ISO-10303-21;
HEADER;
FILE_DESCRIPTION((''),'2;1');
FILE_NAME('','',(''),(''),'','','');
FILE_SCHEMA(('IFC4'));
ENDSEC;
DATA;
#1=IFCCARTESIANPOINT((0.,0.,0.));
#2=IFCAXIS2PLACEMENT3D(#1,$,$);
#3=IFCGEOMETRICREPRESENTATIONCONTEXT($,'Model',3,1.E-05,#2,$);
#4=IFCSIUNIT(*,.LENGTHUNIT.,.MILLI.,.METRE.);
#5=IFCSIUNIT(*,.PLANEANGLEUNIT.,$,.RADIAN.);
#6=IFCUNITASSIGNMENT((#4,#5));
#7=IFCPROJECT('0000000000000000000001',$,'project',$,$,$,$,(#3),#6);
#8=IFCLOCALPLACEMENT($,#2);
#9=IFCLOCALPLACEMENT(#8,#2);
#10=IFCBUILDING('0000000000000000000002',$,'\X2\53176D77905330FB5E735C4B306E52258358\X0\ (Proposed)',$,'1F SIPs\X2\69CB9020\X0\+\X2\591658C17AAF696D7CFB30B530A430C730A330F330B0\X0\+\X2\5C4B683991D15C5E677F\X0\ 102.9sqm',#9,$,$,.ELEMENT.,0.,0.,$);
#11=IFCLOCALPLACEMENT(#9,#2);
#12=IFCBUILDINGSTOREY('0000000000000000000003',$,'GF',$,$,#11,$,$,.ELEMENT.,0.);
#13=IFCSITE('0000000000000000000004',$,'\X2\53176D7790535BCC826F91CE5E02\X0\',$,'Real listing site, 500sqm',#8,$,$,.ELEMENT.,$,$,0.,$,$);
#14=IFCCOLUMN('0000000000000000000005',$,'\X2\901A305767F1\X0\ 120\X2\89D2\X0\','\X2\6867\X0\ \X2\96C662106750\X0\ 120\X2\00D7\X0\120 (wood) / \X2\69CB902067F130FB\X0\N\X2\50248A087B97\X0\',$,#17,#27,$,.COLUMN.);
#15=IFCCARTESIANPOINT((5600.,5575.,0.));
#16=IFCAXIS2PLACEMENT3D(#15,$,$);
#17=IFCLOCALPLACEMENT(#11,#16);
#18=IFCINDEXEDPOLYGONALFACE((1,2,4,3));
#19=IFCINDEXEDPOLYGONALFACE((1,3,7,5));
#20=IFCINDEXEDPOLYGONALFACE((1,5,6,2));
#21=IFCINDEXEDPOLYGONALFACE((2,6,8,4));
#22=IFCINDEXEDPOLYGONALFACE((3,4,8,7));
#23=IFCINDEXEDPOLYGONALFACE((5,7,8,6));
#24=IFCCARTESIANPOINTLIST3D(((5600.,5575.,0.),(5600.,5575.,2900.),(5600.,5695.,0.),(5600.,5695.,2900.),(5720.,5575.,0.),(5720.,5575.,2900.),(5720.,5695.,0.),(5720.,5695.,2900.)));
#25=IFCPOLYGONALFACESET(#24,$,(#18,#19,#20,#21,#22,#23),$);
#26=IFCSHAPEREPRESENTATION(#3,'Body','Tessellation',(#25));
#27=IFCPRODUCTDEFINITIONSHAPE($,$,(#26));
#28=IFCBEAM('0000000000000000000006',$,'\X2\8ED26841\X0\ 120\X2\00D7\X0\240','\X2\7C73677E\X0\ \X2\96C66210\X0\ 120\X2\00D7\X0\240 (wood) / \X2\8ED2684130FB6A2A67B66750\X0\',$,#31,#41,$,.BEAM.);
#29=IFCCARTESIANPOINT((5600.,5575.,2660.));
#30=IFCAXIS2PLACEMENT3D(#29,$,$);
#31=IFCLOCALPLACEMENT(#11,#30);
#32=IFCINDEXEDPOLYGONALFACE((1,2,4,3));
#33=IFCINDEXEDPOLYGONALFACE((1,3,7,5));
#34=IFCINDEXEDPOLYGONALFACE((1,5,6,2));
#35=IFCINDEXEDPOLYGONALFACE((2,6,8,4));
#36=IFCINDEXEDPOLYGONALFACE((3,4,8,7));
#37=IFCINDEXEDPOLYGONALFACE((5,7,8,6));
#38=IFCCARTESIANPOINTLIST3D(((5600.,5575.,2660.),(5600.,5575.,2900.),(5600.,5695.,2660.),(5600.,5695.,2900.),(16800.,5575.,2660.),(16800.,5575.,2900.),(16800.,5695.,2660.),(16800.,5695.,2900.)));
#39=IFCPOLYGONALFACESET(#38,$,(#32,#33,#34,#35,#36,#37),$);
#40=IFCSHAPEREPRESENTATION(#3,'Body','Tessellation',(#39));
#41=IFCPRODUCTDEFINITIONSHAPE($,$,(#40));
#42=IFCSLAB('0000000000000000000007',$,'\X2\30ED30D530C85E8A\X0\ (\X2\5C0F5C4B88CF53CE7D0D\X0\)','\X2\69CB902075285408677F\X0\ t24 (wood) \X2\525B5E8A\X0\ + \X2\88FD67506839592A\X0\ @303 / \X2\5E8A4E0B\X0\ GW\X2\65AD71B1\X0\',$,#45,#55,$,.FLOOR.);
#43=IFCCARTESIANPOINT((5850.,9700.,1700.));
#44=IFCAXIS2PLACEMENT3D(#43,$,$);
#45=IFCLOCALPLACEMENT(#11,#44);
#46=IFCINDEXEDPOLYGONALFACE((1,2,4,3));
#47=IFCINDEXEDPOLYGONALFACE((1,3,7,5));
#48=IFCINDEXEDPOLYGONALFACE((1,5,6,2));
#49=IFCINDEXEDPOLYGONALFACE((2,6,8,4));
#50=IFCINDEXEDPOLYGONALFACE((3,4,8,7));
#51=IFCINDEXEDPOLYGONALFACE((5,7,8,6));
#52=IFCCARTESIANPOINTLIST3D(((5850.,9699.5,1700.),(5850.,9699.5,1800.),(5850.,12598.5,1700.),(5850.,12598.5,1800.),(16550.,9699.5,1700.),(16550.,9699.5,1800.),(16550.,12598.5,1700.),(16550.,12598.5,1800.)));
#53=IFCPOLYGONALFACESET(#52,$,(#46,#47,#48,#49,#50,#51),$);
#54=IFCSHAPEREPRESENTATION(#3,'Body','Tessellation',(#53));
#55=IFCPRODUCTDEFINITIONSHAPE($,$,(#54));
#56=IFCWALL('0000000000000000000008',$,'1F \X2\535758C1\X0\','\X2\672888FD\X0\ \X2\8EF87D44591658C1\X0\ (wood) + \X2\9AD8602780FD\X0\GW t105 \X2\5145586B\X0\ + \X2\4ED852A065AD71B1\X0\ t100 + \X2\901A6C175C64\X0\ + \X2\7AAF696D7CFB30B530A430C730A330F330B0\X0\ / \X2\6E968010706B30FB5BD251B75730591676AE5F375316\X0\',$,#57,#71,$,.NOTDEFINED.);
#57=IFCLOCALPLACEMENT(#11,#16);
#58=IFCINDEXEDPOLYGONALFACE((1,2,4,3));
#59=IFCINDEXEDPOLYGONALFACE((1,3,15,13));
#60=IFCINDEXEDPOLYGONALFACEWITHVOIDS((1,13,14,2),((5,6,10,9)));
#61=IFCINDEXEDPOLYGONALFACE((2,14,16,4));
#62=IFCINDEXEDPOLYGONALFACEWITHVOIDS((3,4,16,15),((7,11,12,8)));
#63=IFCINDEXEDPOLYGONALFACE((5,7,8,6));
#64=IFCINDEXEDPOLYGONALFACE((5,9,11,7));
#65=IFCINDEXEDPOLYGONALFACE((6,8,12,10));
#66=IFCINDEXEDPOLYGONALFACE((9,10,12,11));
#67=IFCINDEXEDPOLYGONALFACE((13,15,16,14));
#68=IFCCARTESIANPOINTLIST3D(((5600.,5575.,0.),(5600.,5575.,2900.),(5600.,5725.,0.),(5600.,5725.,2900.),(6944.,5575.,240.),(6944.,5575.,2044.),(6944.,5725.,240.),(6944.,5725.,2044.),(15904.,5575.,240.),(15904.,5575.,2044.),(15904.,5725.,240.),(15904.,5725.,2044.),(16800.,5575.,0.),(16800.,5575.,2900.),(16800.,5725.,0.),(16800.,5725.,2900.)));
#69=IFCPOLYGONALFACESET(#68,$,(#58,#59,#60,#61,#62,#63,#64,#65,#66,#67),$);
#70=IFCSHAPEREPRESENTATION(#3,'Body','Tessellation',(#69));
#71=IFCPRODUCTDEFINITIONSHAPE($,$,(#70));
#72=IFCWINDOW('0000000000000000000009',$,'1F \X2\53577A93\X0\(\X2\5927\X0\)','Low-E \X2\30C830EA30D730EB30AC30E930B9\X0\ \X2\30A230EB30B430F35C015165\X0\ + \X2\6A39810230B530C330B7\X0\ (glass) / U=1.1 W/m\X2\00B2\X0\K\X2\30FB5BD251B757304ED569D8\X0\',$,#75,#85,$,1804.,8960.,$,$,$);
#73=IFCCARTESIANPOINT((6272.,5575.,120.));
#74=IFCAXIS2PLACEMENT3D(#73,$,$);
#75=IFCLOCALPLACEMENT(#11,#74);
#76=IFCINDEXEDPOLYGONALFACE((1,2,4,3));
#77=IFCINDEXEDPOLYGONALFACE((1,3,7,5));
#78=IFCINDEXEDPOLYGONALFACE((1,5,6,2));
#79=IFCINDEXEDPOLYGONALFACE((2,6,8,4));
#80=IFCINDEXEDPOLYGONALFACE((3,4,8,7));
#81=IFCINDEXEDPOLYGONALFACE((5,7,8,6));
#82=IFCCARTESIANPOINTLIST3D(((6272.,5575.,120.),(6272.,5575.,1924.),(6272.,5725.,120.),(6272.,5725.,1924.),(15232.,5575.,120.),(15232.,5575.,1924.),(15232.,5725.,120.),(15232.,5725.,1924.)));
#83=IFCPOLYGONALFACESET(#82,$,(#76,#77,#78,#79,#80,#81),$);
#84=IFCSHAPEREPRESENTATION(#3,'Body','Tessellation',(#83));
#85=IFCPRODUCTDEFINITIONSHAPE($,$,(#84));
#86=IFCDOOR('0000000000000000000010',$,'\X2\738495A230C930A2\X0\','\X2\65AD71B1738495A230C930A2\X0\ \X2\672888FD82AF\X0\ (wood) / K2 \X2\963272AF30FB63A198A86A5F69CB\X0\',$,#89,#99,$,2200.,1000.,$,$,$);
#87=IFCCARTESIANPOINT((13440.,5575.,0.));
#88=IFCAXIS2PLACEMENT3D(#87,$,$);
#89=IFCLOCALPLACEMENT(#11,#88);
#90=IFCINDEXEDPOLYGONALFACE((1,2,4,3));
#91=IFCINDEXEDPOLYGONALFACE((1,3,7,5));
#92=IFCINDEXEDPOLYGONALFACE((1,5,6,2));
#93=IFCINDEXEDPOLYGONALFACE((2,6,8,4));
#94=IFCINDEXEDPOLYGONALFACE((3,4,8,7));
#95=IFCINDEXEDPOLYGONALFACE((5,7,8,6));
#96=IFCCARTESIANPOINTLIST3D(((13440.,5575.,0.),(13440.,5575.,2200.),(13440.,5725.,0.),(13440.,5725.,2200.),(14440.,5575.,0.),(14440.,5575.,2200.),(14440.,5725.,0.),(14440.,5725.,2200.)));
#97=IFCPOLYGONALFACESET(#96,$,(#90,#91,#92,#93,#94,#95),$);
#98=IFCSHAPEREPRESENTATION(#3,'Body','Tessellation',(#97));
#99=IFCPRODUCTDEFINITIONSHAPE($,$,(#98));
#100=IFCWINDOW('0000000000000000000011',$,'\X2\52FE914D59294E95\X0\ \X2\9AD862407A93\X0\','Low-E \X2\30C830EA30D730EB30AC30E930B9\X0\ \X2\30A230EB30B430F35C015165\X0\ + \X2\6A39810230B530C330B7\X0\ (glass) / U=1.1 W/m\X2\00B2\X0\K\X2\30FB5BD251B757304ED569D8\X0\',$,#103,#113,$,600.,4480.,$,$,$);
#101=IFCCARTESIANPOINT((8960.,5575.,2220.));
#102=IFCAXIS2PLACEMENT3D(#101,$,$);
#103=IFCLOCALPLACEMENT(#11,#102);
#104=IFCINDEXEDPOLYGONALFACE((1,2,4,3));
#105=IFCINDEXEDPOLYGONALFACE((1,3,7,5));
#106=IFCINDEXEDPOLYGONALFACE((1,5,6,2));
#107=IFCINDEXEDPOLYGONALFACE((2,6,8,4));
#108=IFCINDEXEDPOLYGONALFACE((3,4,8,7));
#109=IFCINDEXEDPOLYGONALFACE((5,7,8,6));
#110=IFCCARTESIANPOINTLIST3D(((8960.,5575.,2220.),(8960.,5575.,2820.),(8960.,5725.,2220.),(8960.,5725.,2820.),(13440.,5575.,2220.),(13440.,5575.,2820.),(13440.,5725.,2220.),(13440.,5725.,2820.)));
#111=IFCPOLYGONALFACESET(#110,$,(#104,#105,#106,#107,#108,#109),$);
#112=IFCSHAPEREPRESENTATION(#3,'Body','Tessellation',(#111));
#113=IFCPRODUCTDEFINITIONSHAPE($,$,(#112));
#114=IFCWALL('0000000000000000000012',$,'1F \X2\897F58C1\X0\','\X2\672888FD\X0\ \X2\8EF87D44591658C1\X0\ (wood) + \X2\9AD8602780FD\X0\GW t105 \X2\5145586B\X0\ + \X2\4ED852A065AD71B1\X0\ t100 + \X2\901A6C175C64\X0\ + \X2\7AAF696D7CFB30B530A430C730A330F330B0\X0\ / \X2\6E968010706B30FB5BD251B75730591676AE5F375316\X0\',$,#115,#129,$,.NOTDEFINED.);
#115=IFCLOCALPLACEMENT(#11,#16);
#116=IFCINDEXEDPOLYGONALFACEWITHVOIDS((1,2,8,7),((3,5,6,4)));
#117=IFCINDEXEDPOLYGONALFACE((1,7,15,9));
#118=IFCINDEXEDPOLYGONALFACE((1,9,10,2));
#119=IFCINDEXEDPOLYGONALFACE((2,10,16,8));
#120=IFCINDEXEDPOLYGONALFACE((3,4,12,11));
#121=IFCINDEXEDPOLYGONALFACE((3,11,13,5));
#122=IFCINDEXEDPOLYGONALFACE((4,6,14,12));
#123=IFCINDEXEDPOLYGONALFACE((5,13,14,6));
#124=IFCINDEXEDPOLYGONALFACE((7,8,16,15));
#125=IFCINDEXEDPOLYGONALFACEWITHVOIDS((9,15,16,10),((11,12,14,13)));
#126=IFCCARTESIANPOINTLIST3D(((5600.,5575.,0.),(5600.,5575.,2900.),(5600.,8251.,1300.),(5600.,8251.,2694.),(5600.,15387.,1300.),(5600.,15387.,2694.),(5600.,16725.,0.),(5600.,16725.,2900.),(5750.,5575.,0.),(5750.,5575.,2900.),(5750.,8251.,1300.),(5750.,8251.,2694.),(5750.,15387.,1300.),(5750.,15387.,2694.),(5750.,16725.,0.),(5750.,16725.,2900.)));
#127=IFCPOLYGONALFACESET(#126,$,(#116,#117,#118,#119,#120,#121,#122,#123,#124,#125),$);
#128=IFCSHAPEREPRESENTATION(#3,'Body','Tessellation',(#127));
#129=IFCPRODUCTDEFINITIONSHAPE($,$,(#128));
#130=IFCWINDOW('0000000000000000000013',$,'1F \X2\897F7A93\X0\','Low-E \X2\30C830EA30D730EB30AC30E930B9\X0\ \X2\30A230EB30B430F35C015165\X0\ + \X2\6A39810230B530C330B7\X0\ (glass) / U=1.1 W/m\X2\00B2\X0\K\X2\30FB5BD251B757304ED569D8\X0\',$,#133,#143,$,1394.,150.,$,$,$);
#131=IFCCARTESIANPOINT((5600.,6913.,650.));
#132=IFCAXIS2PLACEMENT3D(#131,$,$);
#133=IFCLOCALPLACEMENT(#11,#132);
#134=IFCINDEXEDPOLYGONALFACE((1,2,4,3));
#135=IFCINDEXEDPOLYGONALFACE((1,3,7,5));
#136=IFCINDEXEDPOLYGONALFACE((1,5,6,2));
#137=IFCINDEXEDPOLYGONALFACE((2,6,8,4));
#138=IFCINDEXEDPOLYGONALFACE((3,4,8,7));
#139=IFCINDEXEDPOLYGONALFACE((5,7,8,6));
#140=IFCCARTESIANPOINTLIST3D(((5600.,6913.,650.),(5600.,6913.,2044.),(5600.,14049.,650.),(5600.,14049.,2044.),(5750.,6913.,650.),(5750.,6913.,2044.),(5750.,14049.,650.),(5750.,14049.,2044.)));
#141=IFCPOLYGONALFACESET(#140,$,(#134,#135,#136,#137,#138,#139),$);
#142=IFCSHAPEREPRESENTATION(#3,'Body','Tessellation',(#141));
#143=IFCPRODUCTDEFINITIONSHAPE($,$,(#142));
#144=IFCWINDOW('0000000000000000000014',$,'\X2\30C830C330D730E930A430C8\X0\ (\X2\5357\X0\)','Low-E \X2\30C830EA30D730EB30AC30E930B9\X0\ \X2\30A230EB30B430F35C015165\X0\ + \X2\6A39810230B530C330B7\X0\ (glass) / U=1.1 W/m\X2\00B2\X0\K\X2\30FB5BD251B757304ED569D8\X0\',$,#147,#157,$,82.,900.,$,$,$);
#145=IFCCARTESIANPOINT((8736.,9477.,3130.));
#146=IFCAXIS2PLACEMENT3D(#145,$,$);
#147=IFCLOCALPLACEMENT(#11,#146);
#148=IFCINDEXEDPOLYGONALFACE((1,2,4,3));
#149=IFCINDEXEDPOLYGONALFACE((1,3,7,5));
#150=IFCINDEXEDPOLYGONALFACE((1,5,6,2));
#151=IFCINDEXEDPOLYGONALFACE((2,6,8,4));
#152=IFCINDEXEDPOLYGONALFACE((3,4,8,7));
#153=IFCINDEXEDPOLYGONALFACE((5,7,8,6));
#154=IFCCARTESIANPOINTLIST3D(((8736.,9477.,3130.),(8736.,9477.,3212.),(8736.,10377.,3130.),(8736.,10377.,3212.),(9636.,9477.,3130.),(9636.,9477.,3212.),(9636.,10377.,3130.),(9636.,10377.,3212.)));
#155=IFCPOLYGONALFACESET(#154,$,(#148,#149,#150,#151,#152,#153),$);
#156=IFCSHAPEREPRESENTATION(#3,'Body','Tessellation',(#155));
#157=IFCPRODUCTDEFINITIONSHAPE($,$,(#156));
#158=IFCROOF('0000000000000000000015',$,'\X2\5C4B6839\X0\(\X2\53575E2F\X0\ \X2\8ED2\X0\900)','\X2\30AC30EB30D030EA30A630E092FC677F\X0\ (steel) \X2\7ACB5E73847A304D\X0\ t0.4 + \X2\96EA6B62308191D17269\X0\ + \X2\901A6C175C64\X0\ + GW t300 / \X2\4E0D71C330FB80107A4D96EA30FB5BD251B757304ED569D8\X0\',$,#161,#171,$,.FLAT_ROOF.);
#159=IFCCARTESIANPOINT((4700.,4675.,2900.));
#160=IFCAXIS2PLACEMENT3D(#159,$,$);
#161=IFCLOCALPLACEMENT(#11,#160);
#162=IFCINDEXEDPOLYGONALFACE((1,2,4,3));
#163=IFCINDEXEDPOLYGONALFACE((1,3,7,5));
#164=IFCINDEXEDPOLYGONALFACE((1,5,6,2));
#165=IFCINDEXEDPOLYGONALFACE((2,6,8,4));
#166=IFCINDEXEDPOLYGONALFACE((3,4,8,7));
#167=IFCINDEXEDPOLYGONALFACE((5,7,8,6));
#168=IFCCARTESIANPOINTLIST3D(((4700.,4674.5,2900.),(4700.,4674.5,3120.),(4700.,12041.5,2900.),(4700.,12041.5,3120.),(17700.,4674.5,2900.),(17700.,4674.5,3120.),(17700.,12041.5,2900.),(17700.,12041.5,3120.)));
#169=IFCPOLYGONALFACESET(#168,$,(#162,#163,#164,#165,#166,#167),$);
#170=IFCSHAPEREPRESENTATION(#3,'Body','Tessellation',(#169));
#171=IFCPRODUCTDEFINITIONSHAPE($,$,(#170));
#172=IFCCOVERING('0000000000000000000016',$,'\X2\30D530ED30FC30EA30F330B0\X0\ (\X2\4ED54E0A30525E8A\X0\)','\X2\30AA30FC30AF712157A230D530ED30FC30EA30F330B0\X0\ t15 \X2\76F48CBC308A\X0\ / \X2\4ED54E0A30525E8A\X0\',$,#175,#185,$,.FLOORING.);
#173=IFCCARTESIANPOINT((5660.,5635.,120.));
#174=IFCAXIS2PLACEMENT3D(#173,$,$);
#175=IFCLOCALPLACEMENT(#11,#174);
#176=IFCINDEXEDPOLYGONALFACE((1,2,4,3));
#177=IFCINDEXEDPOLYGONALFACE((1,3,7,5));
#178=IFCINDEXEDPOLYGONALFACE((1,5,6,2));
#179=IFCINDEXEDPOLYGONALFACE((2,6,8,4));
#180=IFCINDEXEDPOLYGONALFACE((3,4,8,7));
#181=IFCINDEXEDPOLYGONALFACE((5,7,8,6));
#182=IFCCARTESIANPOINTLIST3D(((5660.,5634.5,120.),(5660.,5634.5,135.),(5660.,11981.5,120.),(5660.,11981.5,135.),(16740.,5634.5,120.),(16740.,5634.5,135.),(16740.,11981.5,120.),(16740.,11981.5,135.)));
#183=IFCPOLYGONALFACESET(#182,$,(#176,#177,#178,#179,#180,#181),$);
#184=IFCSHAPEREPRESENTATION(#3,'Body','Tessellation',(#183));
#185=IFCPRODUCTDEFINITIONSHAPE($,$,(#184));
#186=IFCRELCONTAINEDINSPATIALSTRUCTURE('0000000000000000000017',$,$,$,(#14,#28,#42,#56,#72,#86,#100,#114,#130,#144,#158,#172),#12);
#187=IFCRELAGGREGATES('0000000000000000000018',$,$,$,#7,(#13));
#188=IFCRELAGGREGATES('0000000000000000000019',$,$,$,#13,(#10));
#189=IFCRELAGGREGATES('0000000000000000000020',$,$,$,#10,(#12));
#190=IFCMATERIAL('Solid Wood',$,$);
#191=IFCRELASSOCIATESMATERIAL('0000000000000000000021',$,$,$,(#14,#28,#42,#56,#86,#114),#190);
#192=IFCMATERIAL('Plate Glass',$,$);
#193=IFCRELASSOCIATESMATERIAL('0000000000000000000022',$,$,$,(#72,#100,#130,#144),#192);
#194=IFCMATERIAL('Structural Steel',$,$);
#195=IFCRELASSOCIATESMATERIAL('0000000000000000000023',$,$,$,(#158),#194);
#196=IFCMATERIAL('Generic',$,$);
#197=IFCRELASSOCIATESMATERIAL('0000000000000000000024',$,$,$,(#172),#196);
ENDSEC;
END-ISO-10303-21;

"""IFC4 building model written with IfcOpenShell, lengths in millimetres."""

from ifc_helpers import new_model, si_unit, frame, frame_2d, origin, place, context, project, spatial, rectangle, extrude, material, element, fill, save


model = new_model("IFC4")

# Units and contexts
model_context = context("Model", 3, precision=1e-05, world=origin())
ifc_project = project(units=[si_unit("LENGTHUNIT", "METRE", prefix="MILLI"), si_unit("PLANEANGLEUNIT", "RADIAN")], contexts=[model_context])

# Site, building, storey
site_placement = place(None, origin())
site = spatial("IfcSite", under=ifc_project, at=site_placement, Name="北海道富良野市", ObjectType="Real listing site, 500sqm", CompositionType="ELEMENT", RefElevation=0.0)
building_placement = place(site_placement, origin())
building = spatial("IfcBuilding", under=site, at=building_placement, Name="北海道・平屋の別荘 (Proposed)", ObjectType="1F SIPs構造+外壁窯業系サイディング+屋根金属板 102.9sqm", CompositionType="ELEMENT", ElevationOfRefHeight=0.0, ElevationOfTerrain=0.0)
storey_placement = place(building_placement, origin())
storey = spatial("IfcBuildingStorey", under=building, at=storey_placement, Name="GF", CompositionType="ELEMENT", Elevation=0.0)

# Column
ifc_material_1 = material(Name="Solid Wood")
column_1_placement = place(storey_placement, frame((5600.0, 5575.0, 0.0)))
element("IfcColumn", 1, at=column_1_placement, inside=storey, material=ifc_material_1, Name="通し柱 120角", Description="桧 集成材 120×120 (wood) / 構造柱・N値計算", PredefinedType="COLUMN", context=model_context, shape_type="SweptSolid", body=[
    extrude(rectangle(XDim=120.0, YDim=120.0, at=frame_2d((60.0, 60.0))), frame((5600.0, 5575.0, 0.0)), (0.0, 0.0, 1.0), 2900.0),
])

# Beam
beam_1_placement = place(storey_placement, frame((5600.0, 5575.0, 2660.0)))
element("IfcBeam", 2, at=beam_1_placement, inside=storey, material=ifc_material_1, Name="軒桁 120×240", Description="米松 集成 120×240 (wood) / 軒桁・横架材", PredefinedType="BEAM", context=model_context, shape_type="SweptSolid", body=[
    extrude(rectangle(XDim=11200.0, YDim=120.0, at=frame_2d((5600.0, 60.0))), frame((5600.0, 5575.0, 2660.0)), (0.0, 0.0, 1.0), 240.0),
])

# Slab
slab_1_placement = place(storey_placement, frame((5850.0, 9700.0, 1700.0)))
element("IfcSlab", 3, at=slab_1_placement, inside=storey, material=ifc_material_1, Name="ロフト床 (小屋裏収納)", Description="構造用合板 t24 (wood) 剛床 + 製材根太 @303 / 床下 GW断熱", PredefinedType="FLOOR", context=model_context, shape_type="SweptSolid", body=[
    extrude(rectangle(XDim=10700.0, YDim=2899.0, at=frame_2d((5350.0, 1449.0))), frame((5850.0, 9700.0, 1700.0)), (0.0, 0.0, 1.0), 100.0),
])

# Wall, openings, windows, door
wall_1_placement = place(storey_placement, frame((5600.0, 5575.0, 0.0)))
wall_1 = element("IfcWall", 4, at=wall_1_placement, inside=storey, material=ifc_material_1, Name="1F 南壁", Description="木製 軸組外壁 (wood) + 高性能GW t105 充填 + 付加断熱 t100 + 通気層 + 窯業系サイディング / 準耐火・寒冷地外皮強化", PredefinedType="NOTDEFINED", context=model_context, shape_type="SweptSolid", body=[
    extrude(rectangle(XDim=11200.0, YDim=150.0, at=frame_2d((5600.0, 75.0))), frame((5600.0, 5575.0, 0.0)), (0.0, 0.0, 1.0), 2900.0),
])
opening_1_placement = place(storey_placement, frame((6272.0, 5575.0, 120.0)))
opening_1 = element("IfcOpeningElement", 5, at=opening_1_placement, cuts=wall_1, PredefinedType="NOTDEFINED", context=model_context, shape_type="SweptSolid", body=[
    extrude(rectangle(XDim=8960.0, YDim=150.0, at=frame_2d((4480.0, 75.0))), frame((6272.0, 5575.0, 120.0)), (0.0, 0.0, 1.0), 1804.0),
])
opening_2_placement = place(storey_placement, frame((13440.0, 5575.0, 0.0)))
opening_2 = element("IfcOpeningElement", 6, at=opening_2_placement, cuts=wall_1, PredefinedType="NOTDEFINED", context=model_context, shape_type="SweptSolid", body=[
    extrude(rectangle(XDim=1000.0, YDim=150.0, at=frame_2d((500.0, 75.0))), frame((13440.0, 5575.0, 0.0)), (0.0, 0.0, 1.0), 2200.0),
])
opening_3_placement = place(storey_placement, frame((8960.0, 5575.0, 2220.0)))
opening_3 = element("IfcOpeningElement", 7, at=opening_3_placement, cuts=wall_1, PredefinedType="NOTDEFINED", context=model_context, shape_type="SweptSolid", body=[
    extrude(rectangle(XDim=4480.0, YDim=150.0, at=frame_2d((2240.0, 75.0))), frame((8960.0, 5575.0, 2220.0)), (0.0, 0.0, 1.0), 600.0),
])
ifc_material_2 = material(Name="Plate Glass")
window_1_placement = place(storey_placement, frame((6272.0, 5575.0, 120.0)))
window_1 = element("IfcWindow", 8, at=window_1_placement, inside=storey, material=ifc_material_2, Name="1F 南窓(大)", Description="Low-E トリプルガラス アルゴン封入 + 樹脂サッシ (glass) / U=1.1 W/m²K・寒冷地仕様", OverallHeight=1804.0, OverallWidth=8960.0, context=model_context, shape_type="SweptSolid", body=[
    extrude(rectangle(XDim=8960.0, YDim=150.0, at=frame_2d((4480.0, 75.0))), frame((6272.0, 5575.0, 120.0)), (0.0, 0.0, 1.0), 1804.0),
])
fill(opening_1, window_1)
door_1_placement = place(storey_placement, frame((13440.0, 5575.0, 0.0)))
door_1 = element("IfcDoor", 9, at=door_1_placement, inside=storey, material=ifc_material_1, Name="玄関ドア", Description="断熱玄関ドア 木製芯 (wood) / K2 防犯・採風機構", OverallHeight=2200.0, OverallWidth=1000.0, context=model_context, shape_type="SweptSolid", body=[
    extrude(rectangle(XDim=1000.0, YDim=150.0, at=frame_2d((500.0, 75.0))), frame((13440.0, 5575.0, 0.0)), (0.0, 0.0, 1.0), 2200.0),
])
fill(opening_2, door_1)
window_2_placement = place(storey_placement, frame((8960.0, 5575.0, 2220.0)))
window_2 = element("IfcWindow", 10, at=window_2_placement, inside=storey, material=ifc_material_2, Name="勾配天井 高所窓", Description="Low-E トリプルガラス アルゴン封入 + 樹脂サッシ (glass) / U=1.1 W/m²K・寒冷地仕様", OverallHeight=600.0, OverallWidth=4480.0, context=model_context, shape_type="SweptSolid", body=[
    extrude(rectangle(XDim=4480.0, YDim=150.0, at=frame_2d((2240.0, 75.0))), frame((8960.0, 5575.0, 2220.0)), (0.0, 0.0, 1.0), 600.0),
])
fill(opening_3, window_2)

# Wall, opening, window
wall_2_placement = place(storey_placement, frame((5600.0, 5575.0, 0.0)))
wall_2 = element("IfcWall", 11, at=wall_2_placement, inside=storey, material=ifc_material_1, Name="1F 西壁", Description="木製 軸組外壁 (wood) + 高性能GW t105 充填 + 付加断熱 t100 + 通気層 + 窯業系サイディング / 準耐火・寒冷地外皮強化", PredefinedType="NOTDEFINED", context=model_context, shape_type="SweptSolid", body=[
    extrude(rectangle(XDim=150.0, YDim=11150.0, at=frame_2d((75.0, 5575.0))), frame((5600.0, 5575.0, 0.0)), (0.0, 0.0, 1.0), 2900.0),
])
opening_4_placement = place(storey_placement, frame((5600.0, 6913.0, 650.0)))
opening_4 = element("IfcOpeningElement", 12, at=opening_4_placement, cuts=wall_2, PredefinedType="NOTDEFINED", context=model_context, shape_type="SweptSolid", body=[
    extrude(rectangle(XDim=150.0, YDim=7136.0, at=frame_2d((75.0, 3568.0))), frame((5600.0, 6913.0, 650.0)), (0.0, 0.0, 1.0), 1394.0),
])
window_3_placement = place(storey_placement, frame((5600.0, 6913.0, 650.0)))
window_3 = element("IfcWindow", 13, at=window_3_placement, inside=storey, material=ifc_material_2, Name="1F 西窓", Description="Low-E トリプルガラス アルゴン封入 + 樹脂サッシ (glass) / U=1.1 W/m²K・寒冷地仕様", OverallHeight=1394.0, OverallWidth=150.0, context=model_context, shape_type="SweptSolid", body=[
    extrude(rectangle(XDim=150.0, YDim=7136.0, at=frame_2d((75.0, 3568.0))), frame((5600.0, 6913.0, 650.0)), (0.0, 0.0, 1.0), 1394.0),
])
fill(opening_4, window_3)

# Window
window_4_placement = place(storey_placement, frame((8736.0, 9477.0, 3130.0)))
element("IfcWindow", 14, at=window_4_placement, inside=storey, material=ifc_material_2, Name="トップライト (南)", Description="Low-E トリプルガラス アルゴン封入 + 樹脂サッシ (glass) / U=1.1 W/m²K・寒冷地仕様", OverallHeight=82.0, OverallWidth=900.0, context=model_context, shape_type="SweptSolid", body=[
    extrude(rectangle(XDim=900.0, YDim=900.0, at=frame_2d((450.0, 450.0))), frame((8736.0, 9477.0, 3130.0)), (0.0, 0.0, 1.0), 82.0),
])

# Roof
ifc_material_3 = material(Name="Structural Steel")
roof_placement = place(storey_placement, frame((4700.0, 4675.0, 2900.0)))
element("IfcRoof", 15, at=roof_placement, inside=storey, material=ifc_material_3, Name="屋根(南帯 軒900)", Description="ガルバリウム鋼板 (steel) 立平葺き t0.4 + 雪止め金物 + 通気層 + GW t300 / 不燃・耐積雪・寒冷地仕様", PredefinedType="FLAT_ROOF", context=model_context, shape_type="SweptSolid", body=[
    extrude(rectangle(XDim=13000.0, YDim=7367.0, at=frame_2d((6500.0, 3683.0))), frame((4700.0, 4675.0, 2900.0)), (0.0, 0.0, 1.0), 220.0),
])

# Covering
ifc_material_4 = material(Name="Generic")
covering_1_placement = place(storey_placement, frame((5660.0, 5635.0, 120.0)))
element("IfcCovering", 16, at=covering_1_placement, inside=storey, material=ifc_material_4, Name="フローリング (仕上げ床)", Description="オーク無垢フローリング t15 直貼り / 仕上げ床", PredefinedType="FLOORING", context=model_context, shape_type="SweptSolid", body=[
    extrude(rectangle(XDim=11080.0, YDim=6347.0, at=frame_2d((5540.0, 3173.0))), frame((5660.0, 5635.0, 120.0)), (0.0, 0.0, 1.0), 15.0),
])

save(model, "model.ifc")
